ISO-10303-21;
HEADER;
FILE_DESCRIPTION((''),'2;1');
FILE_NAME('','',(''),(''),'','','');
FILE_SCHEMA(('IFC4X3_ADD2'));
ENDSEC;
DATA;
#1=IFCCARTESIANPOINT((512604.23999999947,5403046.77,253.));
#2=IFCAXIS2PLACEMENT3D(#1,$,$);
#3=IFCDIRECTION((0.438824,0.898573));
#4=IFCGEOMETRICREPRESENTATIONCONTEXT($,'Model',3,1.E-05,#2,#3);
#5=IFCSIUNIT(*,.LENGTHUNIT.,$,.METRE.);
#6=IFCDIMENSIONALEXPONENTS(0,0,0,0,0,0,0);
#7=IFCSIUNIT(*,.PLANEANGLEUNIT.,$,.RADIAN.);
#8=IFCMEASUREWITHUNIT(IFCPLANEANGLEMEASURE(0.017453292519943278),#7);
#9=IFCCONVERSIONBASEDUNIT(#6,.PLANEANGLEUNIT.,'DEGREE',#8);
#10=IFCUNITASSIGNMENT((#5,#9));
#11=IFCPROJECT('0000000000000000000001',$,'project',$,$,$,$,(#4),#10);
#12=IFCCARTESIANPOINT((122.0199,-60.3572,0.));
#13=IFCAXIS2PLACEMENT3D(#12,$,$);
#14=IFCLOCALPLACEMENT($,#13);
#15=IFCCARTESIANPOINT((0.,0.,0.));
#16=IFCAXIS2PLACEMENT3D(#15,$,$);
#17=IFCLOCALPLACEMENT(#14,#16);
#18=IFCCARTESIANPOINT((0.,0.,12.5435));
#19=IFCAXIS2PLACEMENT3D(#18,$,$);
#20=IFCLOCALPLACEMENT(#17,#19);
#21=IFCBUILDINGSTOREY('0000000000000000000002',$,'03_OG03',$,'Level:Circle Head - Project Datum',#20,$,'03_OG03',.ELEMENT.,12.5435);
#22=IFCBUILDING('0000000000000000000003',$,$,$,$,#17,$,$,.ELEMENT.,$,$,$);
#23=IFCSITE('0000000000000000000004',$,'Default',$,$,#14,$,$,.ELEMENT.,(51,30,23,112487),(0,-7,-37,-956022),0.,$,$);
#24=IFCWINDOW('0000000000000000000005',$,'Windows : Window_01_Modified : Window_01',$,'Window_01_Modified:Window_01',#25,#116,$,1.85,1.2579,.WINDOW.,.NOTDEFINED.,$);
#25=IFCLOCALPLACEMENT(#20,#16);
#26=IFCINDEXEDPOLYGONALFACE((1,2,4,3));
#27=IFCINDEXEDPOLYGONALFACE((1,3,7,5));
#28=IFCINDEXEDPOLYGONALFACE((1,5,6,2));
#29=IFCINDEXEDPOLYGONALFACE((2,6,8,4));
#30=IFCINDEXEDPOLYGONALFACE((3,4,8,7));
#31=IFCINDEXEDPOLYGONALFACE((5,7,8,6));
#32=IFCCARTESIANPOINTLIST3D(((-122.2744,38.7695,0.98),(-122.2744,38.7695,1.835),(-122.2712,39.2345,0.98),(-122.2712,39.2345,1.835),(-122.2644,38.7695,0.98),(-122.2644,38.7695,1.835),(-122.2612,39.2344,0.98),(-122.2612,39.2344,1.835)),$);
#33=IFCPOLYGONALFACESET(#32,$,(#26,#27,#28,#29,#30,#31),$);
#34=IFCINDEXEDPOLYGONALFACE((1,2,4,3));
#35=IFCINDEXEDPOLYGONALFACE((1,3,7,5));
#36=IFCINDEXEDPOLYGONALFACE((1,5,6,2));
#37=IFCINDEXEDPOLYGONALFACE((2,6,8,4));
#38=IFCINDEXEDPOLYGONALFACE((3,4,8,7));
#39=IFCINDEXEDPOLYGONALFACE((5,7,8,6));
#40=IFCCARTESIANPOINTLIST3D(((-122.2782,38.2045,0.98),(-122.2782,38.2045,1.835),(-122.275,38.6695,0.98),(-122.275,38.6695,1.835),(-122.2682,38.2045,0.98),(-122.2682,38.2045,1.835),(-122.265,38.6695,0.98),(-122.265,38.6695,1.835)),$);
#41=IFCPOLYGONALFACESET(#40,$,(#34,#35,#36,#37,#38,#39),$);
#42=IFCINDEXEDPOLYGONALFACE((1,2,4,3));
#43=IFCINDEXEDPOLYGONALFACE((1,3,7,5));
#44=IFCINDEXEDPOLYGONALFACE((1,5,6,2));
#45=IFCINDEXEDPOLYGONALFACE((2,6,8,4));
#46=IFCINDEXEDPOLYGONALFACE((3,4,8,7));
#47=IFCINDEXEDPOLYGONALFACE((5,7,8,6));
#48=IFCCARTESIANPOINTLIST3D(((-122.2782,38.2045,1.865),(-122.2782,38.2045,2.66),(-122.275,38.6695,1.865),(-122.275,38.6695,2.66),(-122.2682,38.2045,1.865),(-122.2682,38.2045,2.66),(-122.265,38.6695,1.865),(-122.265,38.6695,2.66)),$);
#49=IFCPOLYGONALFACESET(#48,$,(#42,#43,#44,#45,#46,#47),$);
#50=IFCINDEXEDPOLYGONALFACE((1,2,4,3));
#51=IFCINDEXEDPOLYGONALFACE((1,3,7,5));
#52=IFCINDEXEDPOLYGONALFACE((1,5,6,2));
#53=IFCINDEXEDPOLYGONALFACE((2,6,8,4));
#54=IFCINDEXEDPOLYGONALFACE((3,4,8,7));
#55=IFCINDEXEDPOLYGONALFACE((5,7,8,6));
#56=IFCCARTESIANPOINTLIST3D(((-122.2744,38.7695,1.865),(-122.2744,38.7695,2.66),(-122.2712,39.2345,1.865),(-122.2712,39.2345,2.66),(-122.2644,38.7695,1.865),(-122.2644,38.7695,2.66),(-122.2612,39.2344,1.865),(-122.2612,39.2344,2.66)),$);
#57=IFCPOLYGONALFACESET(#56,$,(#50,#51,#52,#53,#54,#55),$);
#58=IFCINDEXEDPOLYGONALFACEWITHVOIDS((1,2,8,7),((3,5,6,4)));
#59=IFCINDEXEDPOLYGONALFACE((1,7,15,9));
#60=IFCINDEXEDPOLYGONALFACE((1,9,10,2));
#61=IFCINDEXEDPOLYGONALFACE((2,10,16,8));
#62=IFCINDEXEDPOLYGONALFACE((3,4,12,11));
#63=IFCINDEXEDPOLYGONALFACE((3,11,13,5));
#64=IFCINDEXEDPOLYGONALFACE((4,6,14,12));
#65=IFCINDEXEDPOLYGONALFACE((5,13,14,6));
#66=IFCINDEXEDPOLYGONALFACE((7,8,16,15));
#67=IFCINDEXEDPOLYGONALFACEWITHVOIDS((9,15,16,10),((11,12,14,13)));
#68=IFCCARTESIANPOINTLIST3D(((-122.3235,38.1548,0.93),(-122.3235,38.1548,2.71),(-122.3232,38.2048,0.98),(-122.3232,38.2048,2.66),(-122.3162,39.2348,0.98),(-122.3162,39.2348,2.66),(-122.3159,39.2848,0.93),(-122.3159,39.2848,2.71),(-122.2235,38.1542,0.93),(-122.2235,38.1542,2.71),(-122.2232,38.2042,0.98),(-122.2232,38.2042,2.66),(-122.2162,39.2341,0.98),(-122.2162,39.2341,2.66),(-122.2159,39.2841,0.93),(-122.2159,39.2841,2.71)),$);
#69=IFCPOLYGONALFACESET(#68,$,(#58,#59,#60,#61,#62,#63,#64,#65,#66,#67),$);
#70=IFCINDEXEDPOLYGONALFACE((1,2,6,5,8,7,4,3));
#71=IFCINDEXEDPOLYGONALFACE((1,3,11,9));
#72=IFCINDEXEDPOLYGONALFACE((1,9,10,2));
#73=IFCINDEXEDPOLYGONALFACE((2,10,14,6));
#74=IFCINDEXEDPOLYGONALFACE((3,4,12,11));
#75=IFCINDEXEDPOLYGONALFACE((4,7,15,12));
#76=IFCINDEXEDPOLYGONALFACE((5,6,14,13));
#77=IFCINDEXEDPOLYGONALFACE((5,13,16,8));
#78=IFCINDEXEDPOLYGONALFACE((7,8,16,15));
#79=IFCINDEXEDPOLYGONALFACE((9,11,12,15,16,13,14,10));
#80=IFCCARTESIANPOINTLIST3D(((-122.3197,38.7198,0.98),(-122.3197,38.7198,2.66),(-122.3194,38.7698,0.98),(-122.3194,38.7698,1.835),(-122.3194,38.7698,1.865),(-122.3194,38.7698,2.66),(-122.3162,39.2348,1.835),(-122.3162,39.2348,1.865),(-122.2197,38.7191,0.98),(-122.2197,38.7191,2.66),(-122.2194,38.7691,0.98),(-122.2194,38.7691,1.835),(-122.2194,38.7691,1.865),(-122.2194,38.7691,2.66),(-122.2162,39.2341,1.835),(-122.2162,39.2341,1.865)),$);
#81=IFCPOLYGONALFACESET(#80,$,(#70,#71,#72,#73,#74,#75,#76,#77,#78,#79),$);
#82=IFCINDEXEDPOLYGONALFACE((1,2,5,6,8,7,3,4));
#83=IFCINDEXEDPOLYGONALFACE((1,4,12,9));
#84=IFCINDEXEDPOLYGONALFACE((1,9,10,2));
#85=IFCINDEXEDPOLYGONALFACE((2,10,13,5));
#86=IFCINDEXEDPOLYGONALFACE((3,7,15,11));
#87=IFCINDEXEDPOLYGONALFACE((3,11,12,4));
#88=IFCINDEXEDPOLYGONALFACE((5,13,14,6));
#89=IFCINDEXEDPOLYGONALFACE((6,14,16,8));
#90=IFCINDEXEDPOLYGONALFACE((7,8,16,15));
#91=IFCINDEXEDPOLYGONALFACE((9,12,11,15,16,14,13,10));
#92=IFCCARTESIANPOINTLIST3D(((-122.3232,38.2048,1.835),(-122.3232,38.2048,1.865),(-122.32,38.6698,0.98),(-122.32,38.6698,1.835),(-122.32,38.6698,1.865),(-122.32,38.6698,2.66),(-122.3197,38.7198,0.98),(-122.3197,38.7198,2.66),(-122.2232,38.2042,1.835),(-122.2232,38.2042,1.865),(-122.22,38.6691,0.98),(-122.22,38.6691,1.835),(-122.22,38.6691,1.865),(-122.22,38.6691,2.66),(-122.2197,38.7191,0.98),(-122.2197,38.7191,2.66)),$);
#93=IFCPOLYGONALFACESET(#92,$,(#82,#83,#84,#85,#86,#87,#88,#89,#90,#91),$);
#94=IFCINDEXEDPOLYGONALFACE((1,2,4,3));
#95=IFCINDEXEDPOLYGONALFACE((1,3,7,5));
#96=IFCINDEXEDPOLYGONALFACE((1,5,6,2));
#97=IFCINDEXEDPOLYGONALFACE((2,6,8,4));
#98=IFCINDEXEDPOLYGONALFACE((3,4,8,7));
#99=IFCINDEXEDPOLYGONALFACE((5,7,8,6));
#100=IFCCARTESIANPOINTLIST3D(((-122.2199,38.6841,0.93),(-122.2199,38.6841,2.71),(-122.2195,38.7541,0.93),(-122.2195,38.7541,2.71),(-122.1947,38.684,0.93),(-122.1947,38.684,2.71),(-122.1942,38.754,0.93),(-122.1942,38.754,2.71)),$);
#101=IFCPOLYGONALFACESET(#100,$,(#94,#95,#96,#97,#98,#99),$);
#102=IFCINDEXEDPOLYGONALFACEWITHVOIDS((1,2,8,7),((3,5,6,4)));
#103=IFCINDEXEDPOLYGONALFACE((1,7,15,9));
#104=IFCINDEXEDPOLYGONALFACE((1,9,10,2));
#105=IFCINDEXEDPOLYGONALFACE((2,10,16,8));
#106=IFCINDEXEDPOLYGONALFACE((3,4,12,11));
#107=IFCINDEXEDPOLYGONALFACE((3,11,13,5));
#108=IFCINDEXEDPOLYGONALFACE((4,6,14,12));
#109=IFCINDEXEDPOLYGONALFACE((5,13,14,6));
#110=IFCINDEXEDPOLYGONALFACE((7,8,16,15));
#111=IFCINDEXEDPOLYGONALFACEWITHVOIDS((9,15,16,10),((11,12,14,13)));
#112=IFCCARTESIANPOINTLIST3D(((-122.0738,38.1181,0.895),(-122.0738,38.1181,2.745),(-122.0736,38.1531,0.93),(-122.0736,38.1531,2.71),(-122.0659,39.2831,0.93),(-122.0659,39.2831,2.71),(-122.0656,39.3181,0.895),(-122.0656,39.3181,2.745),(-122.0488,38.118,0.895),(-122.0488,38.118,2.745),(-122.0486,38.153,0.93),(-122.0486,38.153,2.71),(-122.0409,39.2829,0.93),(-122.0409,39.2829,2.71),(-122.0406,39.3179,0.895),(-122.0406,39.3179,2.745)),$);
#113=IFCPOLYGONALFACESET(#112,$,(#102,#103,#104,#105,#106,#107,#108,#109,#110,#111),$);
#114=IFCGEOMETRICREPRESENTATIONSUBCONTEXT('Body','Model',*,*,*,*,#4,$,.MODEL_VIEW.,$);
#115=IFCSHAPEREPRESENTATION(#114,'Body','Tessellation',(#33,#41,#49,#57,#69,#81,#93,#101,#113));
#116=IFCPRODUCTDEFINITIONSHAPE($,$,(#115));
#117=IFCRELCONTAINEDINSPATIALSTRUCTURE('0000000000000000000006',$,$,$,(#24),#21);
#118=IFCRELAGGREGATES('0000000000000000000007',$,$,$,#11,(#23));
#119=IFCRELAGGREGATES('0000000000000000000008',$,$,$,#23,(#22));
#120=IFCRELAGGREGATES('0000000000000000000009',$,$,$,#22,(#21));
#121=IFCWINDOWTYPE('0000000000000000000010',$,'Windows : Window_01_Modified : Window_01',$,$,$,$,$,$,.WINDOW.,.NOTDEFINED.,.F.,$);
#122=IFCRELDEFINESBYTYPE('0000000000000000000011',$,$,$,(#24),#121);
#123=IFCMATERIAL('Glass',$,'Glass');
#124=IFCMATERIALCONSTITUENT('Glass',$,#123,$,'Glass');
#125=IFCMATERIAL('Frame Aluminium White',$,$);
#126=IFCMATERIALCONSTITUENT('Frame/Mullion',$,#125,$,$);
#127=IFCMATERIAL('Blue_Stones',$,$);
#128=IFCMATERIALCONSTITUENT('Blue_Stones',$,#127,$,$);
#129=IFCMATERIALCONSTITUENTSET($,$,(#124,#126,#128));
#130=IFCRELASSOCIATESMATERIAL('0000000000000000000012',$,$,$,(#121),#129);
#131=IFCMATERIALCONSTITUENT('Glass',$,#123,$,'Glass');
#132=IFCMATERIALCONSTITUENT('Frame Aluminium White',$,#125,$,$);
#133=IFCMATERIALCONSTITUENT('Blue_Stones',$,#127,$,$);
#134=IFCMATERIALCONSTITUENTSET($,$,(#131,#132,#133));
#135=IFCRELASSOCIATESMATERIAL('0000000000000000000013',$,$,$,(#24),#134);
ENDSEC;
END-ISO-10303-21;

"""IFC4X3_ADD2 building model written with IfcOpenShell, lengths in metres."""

from ifc_helpers import new_model, entity, si_unit, converted_unit, direction, frame, frame_2d, origin, place, context, subcontext, project, spatial, polyline, rectangle, outline, extrude, source, transform, mapped, material, constituent, constituent_set, type_object, type_shapes, element, save


model = new_model("IFC4X3_ADD2")

# Units and contexts
model_context = context("Model", 3, precision=1e-05, world=frame((512604.23999999947, 5403046.77, 253.0)), true_north=direction((0.438824, 0.898573)))
body_context = subcontext(model_context, "Body", "Model", "MODEL_VIEW")
ifc_project = project(units=[si_unit("LENGTHUNIT", "METRE"), converted_unit("PLANEANGLEUNIT", "DEGREE", entity("IfcPlaneAngleMeasure", 0.017453292519943278), si_unit("PLANEANGLEUNIT", "RADIAN"), dimensions=[0, 0, 0, 0, 0, 0, 0])], contexts=[model_context])

# Site, building, storey
site_placement = place(None, frame((122.0199, -60.3572, 0.0)))
site = spatial("IfcSite", under=ifc_project, at=site_placement, Name="Default", CompositionType="ELEMENT", RefLatitude=(51, 30, 23, 112487), RefLongitude=(0, -7, -37, -956022), RefElevation=0.0)
building_placement = place(site_placement, origin())
building = spatial("IfcBuilding", under=site, at=building_placement, CompositionType="ELEMENT")
storey_placement = place(building_placement, frame((0.0, 0.0, 12.5435)))
storey = spatial("IfcBuildingStorey", under=building, at=storey_placement, Name="03_OG03", ObjectType="Level:Circle Head - Project Datum", LongName="03_OG03", CompositionType="ELEMENT", Elevation=12.5435)

# Window
ifc_material_1 = material(Name="Glass", Category="Glass")
ifc_material_2 = material(Name="Frame Aluminium White")
ifc_material_3 = material(Name="Blue_Stones")
ifc_constituent_1 = constituent(ifc_material_1, Name="Glass", Category="Glass")
ifc_constituent_2 = constituent(ifc_material_2, Name="Frame Aluminium White")
ifc_constituent_3 = constituent(ifc_material_3, Name="Blue_Stones")
ifc_constituent_set_1 = constituent_set(constituents=[ifc_constituent_1, ifc_constituent_2, ifc_constituent_3])
ifc_constituent_4 = constituent(ifc_material_1, Name="Glass", Category="Glass")
ifc_constituent_5 = constituent(ifc_material_2, Name="Frame/Mullion")
ifc_constituent_6 = constituent(ifc_material_3, Name="Blue_Stones")
ifc_constituent_set_2 = constituent_set(constituents=[ifc_constituent_4, ifc_constituent_5, ifc_constituent_6])
window_type_1 = type_object("IfcWindowType", Name="Windows : Window_01_Modified : Window_01", ParameterTakesPrecedence=False, PartitioningType="NOTDEFINED", PredefinedType="WINDOW", material=ifc_constituent_set_2)
shared_shape_1 = source(origin(), body_context, "Body", "SweptSolid", [
    extrude(rectangle(XDim=0.465, YDim=0.01, at=frame_2d((0.0, 0.0), x_axis=(1.0, 0.0))), frame((0.3476, -0.2, 0.0514), z_axis=(0.0, 0.0, 1.0), x_axis=(-1.0, 0.0, 0.0)), (0.0, 0.0, 1.0), 0.855),
    extrude(rectangle(XDim=0.01, YDim=0.465, at=frame_2d((0.0, 0.0), x_axis=(1.0, 0.0))), frame((0.9126, -0.2, 0.0514), z_axis=(0.0, 0.0, 1.0), x_axis=(0.0, 1.0, 0.0)), (0.0, 0.0, 1.0), 0.855),
    extrude(rectangle(XDim=0.465, YDim=0.01, at=frame_2d((0.0, 0.0), x_axis=(1.0, 0.0))), frame((0.9126, -0.2, 0.9364), z_axis=(0.0, 0.0, 1.0), x_axis=(-1.0, 0.0, 0.0)), (0.0, 0.0, 1.0), 0.795),
    extrude(rectangle(XDim=0.465, YDim=0.01, at=frame_2d((0.0, 0.0), x_axis=(1.0, 0.0))), frame((0.3476, -0.2, 0.9364), z_axis=(0.0, 0.0, 1.0), x_axis=(-1.0, 0.0, 0.0)), (0.0, 0.0, 1.0), 0.795),
    extrude(outline(polyline([(-0.89, -0.565), (0.89, -0.565), (0.89, 0.565), (-0.89, 0.565), (-0.89, -0.565)]), holes=[polyline([(0.84, 0.515), (0.84, -0.515), (-0.84, -0.515), (-0.84, 0.515), (0.84, 0.515)])]), frame((0.6301, -0.25, 0.8914), z_axis=(0.0, 1.0, 0.0), x_axis=(0.0, 0.0, 1.0)), (0.0, 0.0, 1.0), 0.1),
    extrude(outline(polyline([(0.03, 0.1037), (0.825, 0.1037), (0.825, 0.1538), (-0.855, 0.1538), (-0.855, 0.1037), (0.0, 0.1037), (0.0, -0.3613), (0.03, -0.3613), (0.03, 0.1037)])), frame((0.4763, -0.25, 0.9064), z_axis=(0.0, 1.0, 0.0), x_axis=(0.0, 0.0, 1.0)), (0.0, 0.0, 1.0), 0.1),
    extrude(outline(polyline([(-0.825, -0.1038), (-0.825, -0.1538), (0.855, -0.1538), (0.855, -0.1038), (0.0, -0.1038), (0.0, 0.3613), (-0.03, 0.3613), (-0.03, -0.1038), (-0.825, -0.1038)])), frame((0.7838, -0.25, 0.9064), z_axis=(0.0, -1.0, 0.0), x_axis=(0.0, 0.0, -1.0)), (0.0, 0.0, -1.0), 0.1),
    extrude(rectangle(XDim=0.0253, YDim=0.07, at=frame_2d((0.0, 0.0), x_axis=(1.0, 0.0))), frame((0.6301, -0.1374, 0.0014), z_axis=(0.0, 0.0, 1.0), x_axis=(0.0, -1.0, 0.0)), (0.0, 0.0, 1.0), 1.78),
    extrude(outline(polyline([(-0.6, -0.925), (0.6, -0.925), (0.6, 0.925), (-0.6, 0.925), (-0.6, -0.925)]), holes=[polyline([(-0.565, -0.89), (-0.565, 0.89), (0.565, 0.89), (0.565, -0.89), (-0.565, -0.89)])]), frame((0.6301, 0.0, 0.8914), z_axis=(0.0, 1.0, 0.0), x_axis=(1.0, 0.0, 0.0)), (0.0, 0.0, 1.0), 0.025),
])
type_shapes(window_type_1, [shared_shape_1])
window_1_placement = place(storey_placement, frame((-122.0654, 39.3482, 0.9286), z_axis=(0.0, 0.0, 1.0), x_axis=(-0.0068, -0.999977, 0.0)))
element("IfcWindow", 1, at=window_1_placement, inside=storey, type_object=window_type_1, material=ifc_constituent_set_1, Name="Windows : Window_01_Modified : Window_01", ObjectType="Window_01_Modified:Window_01", OverallHeight=1.85, OverallWidth=1.2579, PartitioningType="NOTDEFINED", PredefinedType="WINDOW", context=body_context, shape_type="MappedRepresentation", body=[
    mapped(shared_shape_1, transform((0.0, 0.0, 0.0), scale=1.0)),
])

save(model, "model.ifc")
